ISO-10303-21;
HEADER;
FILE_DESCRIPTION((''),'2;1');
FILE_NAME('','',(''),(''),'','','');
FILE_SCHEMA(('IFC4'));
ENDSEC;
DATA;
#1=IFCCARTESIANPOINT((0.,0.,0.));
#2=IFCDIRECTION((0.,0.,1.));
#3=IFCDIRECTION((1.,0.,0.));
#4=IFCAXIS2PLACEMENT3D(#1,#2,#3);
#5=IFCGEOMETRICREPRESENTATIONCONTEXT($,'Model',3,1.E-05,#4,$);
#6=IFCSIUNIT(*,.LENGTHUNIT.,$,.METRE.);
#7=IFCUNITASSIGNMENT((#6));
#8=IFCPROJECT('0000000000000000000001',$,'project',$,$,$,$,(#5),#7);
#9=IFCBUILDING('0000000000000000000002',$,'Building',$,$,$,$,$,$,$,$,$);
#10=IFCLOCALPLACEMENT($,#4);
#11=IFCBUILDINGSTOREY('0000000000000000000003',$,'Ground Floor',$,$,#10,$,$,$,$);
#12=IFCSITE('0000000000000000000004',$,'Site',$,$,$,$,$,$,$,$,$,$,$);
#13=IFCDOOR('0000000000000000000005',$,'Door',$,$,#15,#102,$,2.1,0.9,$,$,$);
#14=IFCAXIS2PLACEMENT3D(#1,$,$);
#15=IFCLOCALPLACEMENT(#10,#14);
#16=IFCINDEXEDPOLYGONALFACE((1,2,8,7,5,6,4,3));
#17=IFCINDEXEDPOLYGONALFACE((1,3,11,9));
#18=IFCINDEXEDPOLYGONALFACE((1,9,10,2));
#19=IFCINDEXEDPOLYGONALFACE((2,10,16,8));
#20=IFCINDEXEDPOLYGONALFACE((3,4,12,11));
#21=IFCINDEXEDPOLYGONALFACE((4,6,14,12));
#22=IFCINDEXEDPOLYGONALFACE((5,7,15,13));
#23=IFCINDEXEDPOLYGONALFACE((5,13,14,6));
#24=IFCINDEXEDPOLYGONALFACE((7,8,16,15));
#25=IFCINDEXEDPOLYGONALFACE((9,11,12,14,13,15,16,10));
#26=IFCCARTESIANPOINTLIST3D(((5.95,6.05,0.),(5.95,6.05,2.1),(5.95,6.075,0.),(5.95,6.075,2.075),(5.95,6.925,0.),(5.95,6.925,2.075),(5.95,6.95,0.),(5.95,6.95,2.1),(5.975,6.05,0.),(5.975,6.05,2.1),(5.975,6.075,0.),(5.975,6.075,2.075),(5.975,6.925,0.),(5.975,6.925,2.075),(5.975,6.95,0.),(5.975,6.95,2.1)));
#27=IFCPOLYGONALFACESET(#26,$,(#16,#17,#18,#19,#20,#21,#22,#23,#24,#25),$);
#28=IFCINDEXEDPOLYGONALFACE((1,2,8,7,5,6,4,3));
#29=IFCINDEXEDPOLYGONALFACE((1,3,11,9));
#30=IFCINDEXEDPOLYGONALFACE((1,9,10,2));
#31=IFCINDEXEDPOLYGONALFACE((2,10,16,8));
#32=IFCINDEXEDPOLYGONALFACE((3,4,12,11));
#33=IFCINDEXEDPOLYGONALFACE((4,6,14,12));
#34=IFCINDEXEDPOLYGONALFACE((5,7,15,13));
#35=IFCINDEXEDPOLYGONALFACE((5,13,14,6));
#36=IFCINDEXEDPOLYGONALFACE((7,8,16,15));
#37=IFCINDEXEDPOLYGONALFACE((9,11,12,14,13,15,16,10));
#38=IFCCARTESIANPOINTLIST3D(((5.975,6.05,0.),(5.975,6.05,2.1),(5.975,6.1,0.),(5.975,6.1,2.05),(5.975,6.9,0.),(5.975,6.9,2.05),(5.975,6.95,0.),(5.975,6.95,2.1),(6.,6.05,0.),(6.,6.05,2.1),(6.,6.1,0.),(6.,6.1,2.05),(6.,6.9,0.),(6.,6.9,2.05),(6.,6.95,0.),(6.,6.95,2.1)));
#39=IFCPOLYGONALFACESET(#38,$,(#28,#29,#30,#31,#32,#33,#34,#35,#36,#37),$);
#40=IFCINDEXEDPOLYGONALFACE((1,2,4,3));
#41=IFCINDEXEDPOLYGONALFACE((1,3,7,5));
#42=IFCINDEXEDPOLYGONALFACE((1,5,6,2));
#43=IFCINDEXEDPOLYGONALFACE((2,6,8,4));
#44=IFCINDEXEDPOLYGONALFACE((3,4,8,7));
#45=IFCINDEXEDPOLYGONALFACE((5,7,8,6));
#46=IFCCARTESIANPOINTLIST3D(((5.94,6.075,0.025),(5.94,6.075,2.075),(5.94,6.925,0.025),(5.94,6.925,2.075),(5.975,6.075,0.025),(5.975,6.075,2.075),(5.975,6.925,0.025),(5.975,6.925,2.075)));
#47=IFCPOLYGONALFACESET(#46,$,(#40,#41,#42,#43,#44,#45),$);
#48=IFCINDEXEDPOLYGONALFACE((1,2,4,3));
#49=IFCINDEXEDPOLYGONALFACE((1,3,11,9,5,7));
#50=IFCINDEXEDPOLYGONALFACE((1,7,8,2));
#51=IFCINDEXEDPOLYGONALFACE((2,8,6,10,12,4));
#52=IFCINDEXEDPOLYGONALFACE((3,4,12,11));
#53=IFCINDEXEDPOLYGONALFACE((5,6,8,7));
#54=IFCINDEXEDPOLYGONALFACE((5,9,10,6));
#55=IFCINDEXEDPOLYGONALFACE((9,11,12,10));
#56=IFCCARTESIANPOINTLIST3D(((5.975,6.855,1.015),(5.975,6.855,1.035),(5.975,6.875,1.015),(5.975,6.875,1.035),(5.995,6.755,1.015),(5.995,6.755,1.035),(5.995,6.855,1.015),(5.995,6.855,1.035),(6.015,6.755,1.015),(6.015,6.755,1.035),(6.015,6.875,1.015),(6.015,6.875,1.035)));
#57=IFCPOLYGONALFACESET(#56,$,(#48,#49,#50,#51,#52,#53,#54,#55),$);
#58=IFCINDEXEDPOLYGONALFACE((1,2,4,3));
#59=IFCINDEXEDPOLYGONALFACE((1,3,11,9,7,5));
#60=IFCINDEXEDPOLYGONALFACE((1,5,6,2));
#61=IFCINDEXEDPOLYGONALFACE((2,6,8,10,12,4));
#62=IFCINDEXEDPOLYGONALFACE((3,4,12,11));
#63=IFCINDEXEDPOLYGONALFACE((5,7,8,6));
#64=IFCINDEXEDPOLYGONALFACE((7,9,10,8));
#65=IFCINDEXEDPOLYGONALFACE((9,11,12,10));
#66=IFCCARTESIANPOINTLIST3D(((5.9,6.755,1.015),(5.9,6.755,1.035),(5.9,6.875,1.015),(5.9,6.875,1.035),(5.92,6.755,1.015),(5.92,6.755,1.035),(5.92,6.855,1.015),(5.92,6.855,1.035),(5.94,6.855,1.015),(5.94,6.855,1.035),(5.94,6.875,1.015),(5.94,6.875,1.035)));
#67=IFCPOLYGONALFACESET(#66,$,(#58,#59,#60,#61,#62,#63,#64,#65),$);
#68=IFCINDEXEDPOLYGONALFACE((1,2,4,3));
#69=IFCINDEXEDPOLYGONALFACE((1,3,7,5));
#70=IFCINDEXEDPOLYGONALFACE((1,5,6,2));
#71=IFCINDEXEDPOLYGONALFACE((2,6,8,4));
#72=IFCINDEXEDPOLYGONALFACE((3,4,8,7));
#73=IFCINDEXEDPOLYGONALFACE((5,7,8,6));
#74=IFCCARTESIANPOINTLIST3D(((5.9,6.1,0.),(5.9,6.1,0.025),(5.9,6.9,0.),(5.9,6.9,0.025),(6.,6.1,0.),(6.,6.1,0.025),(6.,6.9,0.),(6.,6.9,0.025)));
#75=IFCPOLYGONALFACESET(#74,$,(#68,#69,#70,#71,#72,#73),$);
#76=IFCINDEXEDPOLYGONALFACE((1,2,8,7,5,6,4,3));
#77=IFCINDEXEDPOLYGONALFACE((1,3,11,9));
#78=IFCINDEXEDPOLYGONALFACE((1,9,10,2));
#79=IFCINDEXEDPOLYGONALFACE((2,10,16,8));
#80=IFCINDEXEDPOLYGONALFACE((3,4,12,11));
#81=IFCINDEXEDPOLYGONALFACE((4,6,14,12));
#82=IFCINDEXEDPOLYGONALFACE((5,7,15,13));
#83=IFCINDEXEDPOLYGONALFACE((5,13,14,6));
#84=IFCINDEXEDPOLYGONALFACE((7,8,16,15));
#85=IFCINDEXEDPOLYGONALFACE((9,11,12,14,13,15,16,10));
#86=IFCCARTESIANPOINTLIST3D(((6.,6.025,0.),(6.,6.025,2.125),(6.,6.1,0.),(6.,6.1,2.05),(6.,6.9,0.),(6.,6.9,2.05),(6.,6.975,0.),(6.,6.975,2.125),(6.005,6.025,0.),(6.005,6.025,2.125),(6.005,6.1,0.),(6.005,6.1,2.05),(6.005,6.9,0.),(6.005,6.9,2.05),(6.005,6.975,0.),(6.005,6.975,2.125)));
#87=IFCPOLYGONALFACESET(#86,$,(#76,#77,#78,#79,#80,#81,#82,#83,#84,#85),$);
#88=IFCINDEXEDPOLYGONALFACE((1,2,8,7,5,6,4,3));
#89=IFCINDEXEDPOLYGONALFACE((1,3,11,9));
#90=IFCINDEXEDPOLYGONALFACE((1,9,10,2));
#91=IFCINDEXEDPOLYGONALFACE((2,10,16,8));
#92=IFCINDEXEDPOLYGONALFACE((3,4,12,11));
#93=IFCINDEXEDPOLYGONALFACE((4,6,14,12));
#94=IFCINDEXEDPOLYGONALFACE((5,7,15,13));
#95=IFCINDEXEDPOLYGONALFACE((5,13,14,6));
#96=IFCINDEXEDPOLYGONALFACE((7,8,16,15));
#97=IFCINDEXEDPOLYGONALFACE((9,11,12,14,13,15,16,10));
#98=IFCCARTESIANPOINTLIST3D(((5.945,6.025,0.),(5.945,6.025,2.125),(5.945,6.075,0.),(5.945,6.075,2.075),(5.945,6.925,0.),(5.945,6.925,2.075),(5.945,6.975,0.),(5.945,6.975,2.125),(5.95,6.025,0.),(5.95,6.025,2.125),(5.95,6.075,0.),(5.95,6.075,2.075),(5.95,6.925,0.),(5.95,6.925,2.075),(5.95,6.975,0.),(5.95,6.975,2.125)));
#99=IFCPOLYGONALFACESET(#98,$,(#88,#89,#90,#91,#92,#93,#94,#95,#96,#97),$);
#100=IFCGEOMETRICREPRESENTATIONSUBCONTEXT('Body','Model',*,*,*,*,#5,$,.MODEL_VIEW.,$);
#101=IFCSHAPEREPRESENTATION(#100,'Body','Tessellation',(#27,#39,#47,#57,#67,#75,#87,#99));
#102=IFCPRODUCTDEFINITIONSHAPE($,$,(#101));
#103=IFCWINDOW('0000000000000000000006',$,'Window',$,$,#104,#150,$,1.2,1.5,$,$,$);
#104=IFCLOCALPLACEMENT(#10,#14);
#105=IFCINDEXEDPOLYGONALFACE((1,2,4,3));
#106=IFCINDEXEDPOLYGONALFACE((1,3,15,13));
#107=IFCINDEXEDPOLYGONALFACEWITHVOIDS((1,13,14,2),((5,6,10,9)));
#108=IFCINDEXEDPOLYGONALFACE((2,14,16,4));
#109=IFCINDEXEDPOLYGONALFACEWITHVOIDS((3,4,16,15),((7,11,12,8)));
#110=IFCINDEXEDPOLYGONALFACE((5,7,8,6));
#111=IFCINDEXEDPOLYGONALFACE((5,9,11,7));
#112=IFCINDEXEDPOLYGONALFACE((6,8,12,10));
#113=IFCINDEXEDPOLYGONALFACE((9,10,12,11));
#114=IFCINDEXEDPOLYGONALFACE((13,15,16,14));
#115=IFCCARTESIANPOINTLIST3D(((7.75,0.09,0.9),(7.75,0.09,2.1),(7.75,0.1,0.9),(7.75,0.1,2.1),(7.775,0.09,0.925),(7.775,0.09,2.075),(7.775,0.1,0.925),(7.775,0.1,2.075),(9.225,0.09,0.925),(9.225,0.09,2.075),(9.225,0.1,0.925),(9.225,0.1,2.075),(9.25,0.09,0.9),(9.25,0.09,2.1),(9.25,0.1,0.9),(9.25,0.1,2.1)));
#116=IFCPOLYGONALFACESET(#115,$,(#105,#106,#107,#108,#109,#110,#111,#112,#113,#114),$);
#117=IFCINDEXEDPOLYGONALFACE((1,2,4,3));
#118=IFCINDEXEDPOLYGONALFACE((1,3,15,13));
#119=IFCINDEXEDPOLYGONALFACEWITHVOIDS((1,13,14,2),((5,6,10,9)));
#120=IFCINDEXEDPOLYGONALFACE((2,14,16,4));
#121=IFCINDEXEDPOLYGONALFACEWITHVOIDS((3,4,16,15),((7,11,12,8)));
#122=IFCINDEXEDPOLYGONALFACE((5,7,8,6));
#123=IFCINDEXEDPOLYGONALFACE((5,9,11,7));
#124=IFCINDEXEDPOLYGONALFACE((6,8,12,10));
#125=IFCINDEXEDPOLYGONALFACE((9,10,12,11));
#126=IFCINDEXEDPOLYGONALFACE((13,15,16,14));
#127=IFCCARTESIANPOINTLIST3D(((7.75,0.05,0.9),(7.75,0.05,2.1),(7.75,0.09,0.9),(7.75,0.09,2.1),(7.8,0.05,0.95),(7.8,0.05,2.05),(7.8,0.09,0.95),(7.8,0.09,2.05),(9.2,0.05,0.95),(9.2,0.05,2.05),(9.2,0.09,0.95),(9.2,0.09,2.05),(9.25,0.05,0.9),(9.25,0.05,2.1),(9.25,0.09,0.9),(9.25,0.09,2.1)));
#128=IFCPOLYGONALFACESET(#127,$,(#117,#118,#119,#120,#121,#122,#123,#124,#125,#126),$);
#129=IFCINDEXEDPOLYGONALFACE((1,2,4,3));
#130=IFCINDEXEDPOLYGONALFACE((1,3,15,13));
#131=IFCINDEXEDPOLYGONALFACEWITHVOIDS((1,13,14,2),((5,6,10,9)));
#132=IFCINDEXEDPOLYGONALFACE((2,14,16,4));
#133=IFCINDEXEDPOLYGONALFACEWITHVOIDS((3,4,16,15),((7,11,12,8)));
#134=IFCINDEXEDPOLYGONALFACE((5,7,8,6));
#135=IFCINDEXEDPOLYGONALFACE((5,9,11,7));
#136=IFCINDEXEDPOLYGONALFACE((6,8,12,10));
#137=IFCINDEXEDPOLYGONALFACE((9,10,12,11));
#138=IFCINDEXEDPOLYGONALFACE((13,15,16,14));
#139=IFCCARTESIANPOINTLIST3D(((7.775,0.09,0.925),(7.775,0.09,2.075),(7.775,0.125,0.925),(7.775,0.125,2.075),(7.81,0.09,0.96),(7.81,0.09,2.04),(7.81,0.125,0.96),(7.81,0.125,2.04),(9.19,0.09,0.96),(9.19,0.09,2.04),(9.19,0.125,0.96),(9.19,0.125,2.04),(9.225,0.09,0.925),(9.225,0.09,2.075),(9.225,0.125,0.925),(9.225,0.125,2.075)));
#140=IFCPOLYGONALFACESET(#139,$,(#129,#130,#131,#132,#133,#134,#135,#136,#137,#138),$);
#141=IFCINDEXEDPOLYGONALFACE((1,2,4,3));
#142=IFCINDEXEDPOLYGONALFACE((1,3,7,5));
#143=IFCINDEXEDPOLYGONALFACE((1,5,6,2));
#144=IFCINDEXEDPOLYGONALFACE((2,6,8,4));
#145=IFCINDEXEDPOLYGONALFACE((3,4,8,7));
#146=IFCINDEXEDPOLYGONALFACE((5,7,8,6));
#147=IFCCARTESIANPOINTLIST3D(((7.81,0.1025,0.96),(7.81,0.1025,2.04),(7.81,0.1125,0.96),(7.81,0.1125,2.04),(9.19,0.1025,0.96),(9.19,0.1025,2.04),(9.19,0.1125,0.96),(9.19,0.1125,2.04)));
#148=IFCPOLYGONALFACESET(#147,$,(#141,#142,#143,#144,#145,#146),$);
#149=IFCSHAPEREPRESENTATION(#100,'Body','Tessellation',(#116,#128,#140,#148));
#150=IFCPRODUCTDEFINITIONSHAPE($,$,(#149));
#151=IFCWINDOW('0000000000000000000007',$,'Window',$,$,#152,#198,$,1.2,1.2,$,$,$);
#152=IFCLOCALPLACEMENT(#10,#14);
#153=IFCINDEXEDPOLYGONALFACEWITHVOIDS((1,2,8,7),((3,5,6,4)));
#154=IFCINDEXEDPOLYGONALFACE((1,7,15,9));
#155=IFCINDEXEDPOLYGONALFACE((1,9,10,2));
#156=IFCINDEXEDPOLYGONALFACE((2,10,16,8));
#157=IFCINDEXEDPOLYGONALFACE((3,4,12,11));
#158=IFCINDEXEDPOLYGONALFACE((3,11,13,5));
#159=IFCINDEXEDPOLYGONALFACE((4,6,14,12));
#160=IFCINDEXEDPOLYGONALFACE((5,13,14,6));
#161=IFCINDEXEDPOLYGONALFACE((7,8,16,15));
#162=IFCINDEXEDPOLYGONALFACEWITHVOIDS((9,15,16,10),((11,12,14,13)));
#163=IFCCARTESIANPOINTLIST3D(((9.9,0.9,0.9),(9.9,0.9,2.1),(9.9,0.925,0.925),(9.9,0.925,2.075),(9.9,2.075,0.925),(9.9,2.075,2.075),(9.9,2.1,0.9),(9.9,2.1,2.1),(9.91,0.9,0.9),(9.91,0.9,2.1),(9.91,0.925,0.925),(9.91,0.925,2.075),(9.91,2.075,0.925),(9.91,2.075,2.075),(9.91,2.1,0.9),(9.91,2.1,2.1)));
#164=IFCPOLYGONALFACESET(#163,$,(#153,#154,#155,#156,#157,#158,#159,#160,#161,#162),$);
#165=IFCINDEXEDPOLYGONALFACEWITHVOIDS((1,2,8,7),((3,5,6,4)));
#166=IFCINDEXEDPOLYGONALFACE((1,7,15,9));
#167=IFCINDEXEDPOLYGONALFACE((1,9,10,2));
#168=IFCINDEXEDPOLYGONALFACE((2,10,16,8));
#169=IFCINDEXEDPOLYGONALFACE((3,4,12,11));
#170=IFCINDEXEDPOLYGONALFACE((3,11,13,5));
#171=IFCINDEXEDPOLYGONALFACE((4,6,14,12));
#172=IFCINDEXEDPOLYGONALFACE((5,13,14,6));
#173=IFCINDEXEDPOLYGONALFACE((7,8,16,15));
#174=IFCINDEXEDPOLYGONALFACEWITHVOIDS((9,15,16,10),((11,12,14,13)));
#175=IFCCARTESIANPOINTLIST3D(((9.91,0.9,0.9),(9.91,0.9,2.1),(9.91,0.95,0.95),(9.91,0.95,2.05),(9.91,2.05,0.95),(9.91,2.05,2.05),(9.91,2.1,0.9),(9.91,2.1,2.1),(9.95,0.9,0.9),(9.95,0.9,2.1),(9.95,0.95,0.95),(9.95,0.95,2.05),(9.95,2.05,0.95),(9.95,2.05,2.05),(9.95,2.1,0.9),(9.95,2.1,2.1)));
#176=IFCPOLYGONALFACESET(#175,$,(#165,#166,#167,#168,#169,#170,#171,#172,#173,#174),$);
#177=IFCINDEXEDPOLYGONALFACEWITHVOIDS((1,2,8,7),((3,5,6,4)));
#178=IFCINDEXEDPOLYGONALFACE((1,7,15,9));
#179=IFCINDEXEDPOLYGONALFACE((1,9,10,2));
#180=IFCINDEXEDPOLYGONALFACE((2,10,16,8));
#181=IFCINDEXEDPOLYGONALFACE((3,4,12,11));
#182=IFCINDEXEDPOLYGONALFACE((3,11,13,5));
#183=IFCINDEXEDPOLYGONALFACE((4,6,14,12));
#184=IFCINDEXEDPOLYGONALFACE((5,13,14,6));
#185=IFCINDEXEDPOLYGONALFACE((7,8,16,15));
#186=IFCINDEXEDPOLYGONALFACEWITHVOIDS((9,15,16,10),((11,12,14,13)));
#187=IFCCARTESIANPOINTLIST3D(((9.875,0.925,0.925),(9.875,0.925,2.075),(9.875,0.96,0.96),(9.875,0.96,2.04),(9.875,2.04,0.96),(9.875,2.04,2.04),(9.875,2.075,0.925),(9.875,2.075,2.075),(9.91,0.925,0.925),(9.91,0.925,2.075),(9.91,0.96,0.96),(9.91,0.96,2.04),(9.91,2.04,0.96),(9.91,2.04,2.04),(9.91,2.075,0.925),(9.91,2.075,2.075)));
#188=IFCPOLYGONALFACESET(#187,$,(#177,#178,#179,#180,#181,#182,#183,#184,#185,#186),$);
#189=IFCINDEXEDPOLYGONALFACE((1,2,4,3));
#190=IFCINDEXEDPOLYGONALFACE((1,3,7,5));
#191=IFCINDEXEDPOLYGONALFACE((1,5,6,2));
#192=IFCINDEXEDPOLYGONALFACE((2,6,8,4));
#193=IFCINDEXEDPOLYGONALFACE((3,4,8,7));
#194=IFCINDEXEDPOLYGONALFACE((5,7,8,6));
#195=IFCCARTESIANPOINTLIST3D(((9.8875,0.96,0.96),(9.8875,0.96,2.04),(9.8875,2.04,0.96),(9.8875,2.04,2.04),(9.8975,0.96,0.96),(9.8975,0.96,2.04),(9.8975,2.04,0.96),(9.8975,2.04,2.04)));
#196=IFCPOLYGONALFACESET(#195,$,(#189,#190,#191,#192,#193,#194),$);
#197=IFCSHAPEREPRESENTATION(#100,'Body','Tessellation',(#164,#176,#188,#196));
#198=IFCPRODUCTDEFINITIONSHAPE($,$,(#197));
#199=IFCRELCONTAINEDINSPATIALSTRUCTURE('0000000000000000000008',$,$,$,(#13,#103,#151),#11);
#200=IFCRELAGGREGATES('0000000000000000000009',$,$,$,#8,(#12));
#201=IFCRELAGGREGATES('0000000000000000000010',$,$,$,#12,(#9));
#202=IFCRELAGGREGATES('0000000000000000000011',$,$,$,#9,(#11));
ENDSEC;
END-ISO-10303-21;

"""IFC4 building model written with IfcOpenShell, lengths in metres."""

from ifc_helpers import new_model, si_unit, frame, origin_with_axes, place, context, subcontext, project, spatial, line, indexed_curve, outline, extrude, element, save


model = new_model("IFC4")

# Units and contexts
model_context = context("Model", 3, precision=1e-05, world=origin_with_axes())
body_context = subcontext(model_context, "Body", "Model", "MODEL_VIEW")
ifc_project = project(units=[si_unit("LENGTHUNIT", "METRE")], contexts=[model_context])

# Site, building, storey
site = spatial("IfcSite", under=ifc_project, Name="Site")
building = spatial("IfcBuilding", under=site, Name="Building")
storey_placement = place(None, origin_with_axes())
storey = spatial("IfcBuildingStorey", under=building, at=storey_placement, Name="Ground Floor")

# Door
door_1_placement = place(storey_placement, frame((6.0, 6.05, 0.0), z_axis=(0.0, 0.0, 1.0), x_axis=(0.0, 1.0, 0.0)))
element("IfcDoor", 1, at=door_1_placement, inside=storey, Name="Door", OverallHeight=2.1, OverallWidth=0.9, context=body_context, shape_type="SweptSolid", body=[
    extrude(outline(indexed_curve([(0.0, 0.0), (0.0, 2.1), (0.9, 2.1), (0.9, 0.0), (0.875, 0.0), (0.875, 2.075), (0.025, 2.075), (0.025, 0.0)], segments=[line(1, 2, 3, 4, 5, 6, 7, 8, 1)])), frame((0.0, 0.025, 0.0), z_axis=(0.0, -1.0, 0.0), x_axis=(1.0, 0.0, 0.0)), (0.0, 0.0, -1.0), 0.025),
    extrude(outline(indexed_curve([(0.0, 0.0), (0.0, 2.1), (0.9, 2.1), (0.9, 0.0), (0.85, 0.0), (0.85, 2.05), (0.05, 2.05), (0.05, 0.0)], segments=[line(1, 2, 3, 4, 5, 6, 7, 8, 1)])), frame((0.0, 0.0, 0.0), z_axis=(0.0, -1.0, 0.0), x_axis=(1.0, 0.0, 0.0)), (0.0, 0.0, -1.0), 0.025),
    extrude(outline(indexed_curve([(0.0, 0.0), (0.85, 0.0), (0.85, 0.035), (0.0, 0.035)], segments=[line(1, 2, 3, 4, 1)])), frame((0.025, 0.025, 0.025), z_axis=(0.0, 0.0, 1.0), x_axis=(1.0, 0.0, 0.0)), (0.0, 0.0, 1.0), 2.05),
    extrude(outline(indexed_curve([(0.0, 0.0), (0.0, -0.04), (-0.12, -0.04), (-0.12, -0.02), (-0.02, -0.02), (-0.02, 0.0)], segments=[line(1, 2, 3, 4, 5, 6, 1)])), frame((0.825, 0.025, 1.015), z_axis=(0.0, 0.0, 1.0), x_axis=(1.0, 0.0, 0.0)), (0.0, 0.0, 1.0), 0.02),
    extrude(outline(indexed_curve([(0.0, 0.0), (0.0, 0.04), (-0.12, 0.04), (-0.12, 0.02), (-0.02, 0.02), (-0.02, 0.0)], segments=[line(1, 2, 3, 4, 5, 6, 1)])), frame((0.825, 0.06, 1.015), z_axis=(0.0, 0.0, 1.0), x_axis=(1.0, 0.0, 0.0)), (0.0, 0.0, 1.0), 0.02),
    extrude(outline(indexed_curve([(0.0, 0.0), (0.8, 0.0), (0.8, 0.1), (0.0, 0.1)], segments=[line(1, 2, 3, 4, 1)])), frame((0.05, 0.0, 0.0), z_axis=(0.0, 0.0, 1.0), x_axis=(1.0, 0.0, 0.0)), (0.0, 0.0, 1.0), 0.025),
    extrude(outline(indexed_curve([(0.0, 0.0), (0.0, 2.125), (0.95, 2.125), (0.95, 0.0), (0.875, 0.0), (0.875, 2.05), (0.075, 2.05), (0.075, 0.0)], segments=[line(1, 2, 3, 4, 5, 6, 7, 8, 1)])), frame((-0.025, -0.005, 0.0), z_axis=(0.0, -1.0, 0.0), x_axis=(1.0, 0.0, 0.0)), (0.0, 0.0, -1.0), 0.005),
    extrude(outline(indexed_curve([(0.0, 0.0), (0.0, 2.125), (0.95, 2.125), (0.95, 0.0), (0.9, 0.0), (0.9, 2.075), (0.05, 2.075), (0.05, 0.0)], segments=[line(1, 2, 3, 4, 5, 6, 7, 8, 1)])), frame((-0.025, 0.05, 0.0), z_axis=(0.0, -1.0, 0.0), x_axis=(1.0, 0.0, 0.0)), (0.0, 0.0, -1.0), 0.005),
])

# Windows
window_1_placement = place(storey_placement, frame((7.75, 0.0, 0.9), z_axis=(0.0, 0.0, 1.0), x_axis=(1.0, 0.0, 0.0)))
element("IfcWindow", 2, at=window_1_placement, inside=storey, Name="Window", OverallHeight=1.2, OverallWidth=1.5, context=body_context, shape_type="SweptSolid", body=[
    extrude(outline(indexed_curve([(0.0, 0.0), (1.5, 0.0), (1.5, 1.2), (0.0, 1.2)], segments=[line(1, 2, 3, 4, 1)]), holes=[indexed_curve([(0.025, 0.025), (1.475, 0.025), (1.475, 1.175), (0.025, 1.175)], segments=[line(1, 2, 3, 4, 1)])]), frame((0.0, 0.09, 0.0), z_axis=(0.0, -1.0, 0.0), x_axis=(1.0, 0.0, 0.0)), (0.0, 0.0, -1.0), 0.01),
    extrude(outline(indexed_curve([(0.0, 0.0), (1.5, 0.0), (1.5, 1.2), (0.0, 1.2)], segments=[line(1, 2, 3, 4, 1)]), holes=[indexed_curve([(0.05, 0.05), (1.45, 0.05), (1.45, 1.15), (0.05, 1.15)], segments=[line(1, 2, 3, 4, 1)])]), frame((0.0, 0.05, 0.0), z_axis=(0.0, -1.0, 0.0), x_axis=(1.0, 0.0, 0.0)), (0.0, 0.0, -1.0), 0.04),
    extrude(outline(indexed_curve([(0.0, 0.0), (1.45, 0.0), (1.45, 1.15), (0.0, 1.15)], segments=[line(1, 2, 3, 4, 1)]), holes=[indexed_curve([(0.035, 0.035), (1.415, 0.035), (1.415, 1.115), (0.035, 1.115)], segments=[line(1, 2, 3, 4, 1)])]), frame((0.025, 0.09, 0.025), z_axis=(0.0, -1.0, 0.0), x_axis=(1.0, 0.0, 0.0)), (0.0, 0.0, -1.0), 0.035),
    extrude(outline(indexed_curve([(0.035, 0.035), (1.415, 0.035), (1.415, 1.115), (0.035, 1.115)], segments=[line(1, 2, 3, 4, 1)])), frame((0.025, 0.1025, 0.025), z_axis=(0.0, -1.0, 0.0), x_axis=(1.0, 0.0, 0.0)), (0.0, 0.0, -1.0), 0.01),
])
window_2_placement = place(storey_placement, frame((10.0, 0.9, 0.9), z_axis=(0.0, 0.0, 1.0), x_axis=(0.0, 1.0, 0.0)))
element("IfcWindow", 3, at=window_2_placement, inside=storey, Name="Window", OverallHeight=1.2, OverallWidth=1.2, context=body_context, shape_type="SweptSolid", body=[
    extrude(outline(indexed_curve([(0.0, 0.0), (1.2, 0.0), (1.2, 1.2), (0.0, 1.2)], segments=[line(1, 2, 3, 4, 1)]), holes=[indexed_curve([(0.025, 0.025), (1.175, 0.025), (1.175, 1.175), (0.025, 1.175)], segments=[line(1, 2, 3, 4, 1)])]), frame((0.0, 0.09, 0.0), z_axis=(0.0, -1.0, 0.0), x_axis=(1.0, 0.0, 0.0)), (0.0, 0.0, -1.0), 0.01),
    extrude(outline(indexed_curve([(0.0, 0.0), (1.2, 0.0), (1.2, 1.2), (0.0, 1.2)], segments=[line(1, 2, 3, 4, 1)]), holes=[indexed_curve([(0.05, 0.05), (1.15, 0.05), (1.15, 1.15), (0.05, 1.15)], segments=[line(1, 2, 3, 4, 1)])]), frame((0.0, 0.05, 0.0), z_axis=(0.0, -1.0, 0.0), x_axis=(1.0, 0.0, 0.0)), (0.0, 0.0, -1.0), 0.04),
    extrude(outline(indexed_curve([(0.0, 0.0), (1.15, 0.0), (1.15, 1.15), (0.0, 1.15)], segments=[line(1, 2, 3, 4, 1)]), holes=[indexed_curve([(0.035, 0.035), (1.115, 0.035), (1.115, 1.115), (0.035, 1.115)], segments=[line(1, 2, 3, 4, 1)])]), frame((0.025, 0.09, 0.025), z_axis=(0.0, -1.0, 0.0), x_axis=(1.0, 0.0, 0.0)), (0.0, 0.0, -1.0), 0.035),
    extrude(outline(indexed_curve([(0.035, 0.035), (1.115, 0.035), (1.115, 1.115), (0.035, 1.115)], segments=[line(1, 2, 3, 4, 1)])), frame((0.025, 0.1025, 0.025), z_axis=(0.0, -1.0, 0.0), x_axis=(1.0, 0.0, 0.0)), (0.0, 0.0, -1.0), 0.01),
])

save(model, "model.ifc")
